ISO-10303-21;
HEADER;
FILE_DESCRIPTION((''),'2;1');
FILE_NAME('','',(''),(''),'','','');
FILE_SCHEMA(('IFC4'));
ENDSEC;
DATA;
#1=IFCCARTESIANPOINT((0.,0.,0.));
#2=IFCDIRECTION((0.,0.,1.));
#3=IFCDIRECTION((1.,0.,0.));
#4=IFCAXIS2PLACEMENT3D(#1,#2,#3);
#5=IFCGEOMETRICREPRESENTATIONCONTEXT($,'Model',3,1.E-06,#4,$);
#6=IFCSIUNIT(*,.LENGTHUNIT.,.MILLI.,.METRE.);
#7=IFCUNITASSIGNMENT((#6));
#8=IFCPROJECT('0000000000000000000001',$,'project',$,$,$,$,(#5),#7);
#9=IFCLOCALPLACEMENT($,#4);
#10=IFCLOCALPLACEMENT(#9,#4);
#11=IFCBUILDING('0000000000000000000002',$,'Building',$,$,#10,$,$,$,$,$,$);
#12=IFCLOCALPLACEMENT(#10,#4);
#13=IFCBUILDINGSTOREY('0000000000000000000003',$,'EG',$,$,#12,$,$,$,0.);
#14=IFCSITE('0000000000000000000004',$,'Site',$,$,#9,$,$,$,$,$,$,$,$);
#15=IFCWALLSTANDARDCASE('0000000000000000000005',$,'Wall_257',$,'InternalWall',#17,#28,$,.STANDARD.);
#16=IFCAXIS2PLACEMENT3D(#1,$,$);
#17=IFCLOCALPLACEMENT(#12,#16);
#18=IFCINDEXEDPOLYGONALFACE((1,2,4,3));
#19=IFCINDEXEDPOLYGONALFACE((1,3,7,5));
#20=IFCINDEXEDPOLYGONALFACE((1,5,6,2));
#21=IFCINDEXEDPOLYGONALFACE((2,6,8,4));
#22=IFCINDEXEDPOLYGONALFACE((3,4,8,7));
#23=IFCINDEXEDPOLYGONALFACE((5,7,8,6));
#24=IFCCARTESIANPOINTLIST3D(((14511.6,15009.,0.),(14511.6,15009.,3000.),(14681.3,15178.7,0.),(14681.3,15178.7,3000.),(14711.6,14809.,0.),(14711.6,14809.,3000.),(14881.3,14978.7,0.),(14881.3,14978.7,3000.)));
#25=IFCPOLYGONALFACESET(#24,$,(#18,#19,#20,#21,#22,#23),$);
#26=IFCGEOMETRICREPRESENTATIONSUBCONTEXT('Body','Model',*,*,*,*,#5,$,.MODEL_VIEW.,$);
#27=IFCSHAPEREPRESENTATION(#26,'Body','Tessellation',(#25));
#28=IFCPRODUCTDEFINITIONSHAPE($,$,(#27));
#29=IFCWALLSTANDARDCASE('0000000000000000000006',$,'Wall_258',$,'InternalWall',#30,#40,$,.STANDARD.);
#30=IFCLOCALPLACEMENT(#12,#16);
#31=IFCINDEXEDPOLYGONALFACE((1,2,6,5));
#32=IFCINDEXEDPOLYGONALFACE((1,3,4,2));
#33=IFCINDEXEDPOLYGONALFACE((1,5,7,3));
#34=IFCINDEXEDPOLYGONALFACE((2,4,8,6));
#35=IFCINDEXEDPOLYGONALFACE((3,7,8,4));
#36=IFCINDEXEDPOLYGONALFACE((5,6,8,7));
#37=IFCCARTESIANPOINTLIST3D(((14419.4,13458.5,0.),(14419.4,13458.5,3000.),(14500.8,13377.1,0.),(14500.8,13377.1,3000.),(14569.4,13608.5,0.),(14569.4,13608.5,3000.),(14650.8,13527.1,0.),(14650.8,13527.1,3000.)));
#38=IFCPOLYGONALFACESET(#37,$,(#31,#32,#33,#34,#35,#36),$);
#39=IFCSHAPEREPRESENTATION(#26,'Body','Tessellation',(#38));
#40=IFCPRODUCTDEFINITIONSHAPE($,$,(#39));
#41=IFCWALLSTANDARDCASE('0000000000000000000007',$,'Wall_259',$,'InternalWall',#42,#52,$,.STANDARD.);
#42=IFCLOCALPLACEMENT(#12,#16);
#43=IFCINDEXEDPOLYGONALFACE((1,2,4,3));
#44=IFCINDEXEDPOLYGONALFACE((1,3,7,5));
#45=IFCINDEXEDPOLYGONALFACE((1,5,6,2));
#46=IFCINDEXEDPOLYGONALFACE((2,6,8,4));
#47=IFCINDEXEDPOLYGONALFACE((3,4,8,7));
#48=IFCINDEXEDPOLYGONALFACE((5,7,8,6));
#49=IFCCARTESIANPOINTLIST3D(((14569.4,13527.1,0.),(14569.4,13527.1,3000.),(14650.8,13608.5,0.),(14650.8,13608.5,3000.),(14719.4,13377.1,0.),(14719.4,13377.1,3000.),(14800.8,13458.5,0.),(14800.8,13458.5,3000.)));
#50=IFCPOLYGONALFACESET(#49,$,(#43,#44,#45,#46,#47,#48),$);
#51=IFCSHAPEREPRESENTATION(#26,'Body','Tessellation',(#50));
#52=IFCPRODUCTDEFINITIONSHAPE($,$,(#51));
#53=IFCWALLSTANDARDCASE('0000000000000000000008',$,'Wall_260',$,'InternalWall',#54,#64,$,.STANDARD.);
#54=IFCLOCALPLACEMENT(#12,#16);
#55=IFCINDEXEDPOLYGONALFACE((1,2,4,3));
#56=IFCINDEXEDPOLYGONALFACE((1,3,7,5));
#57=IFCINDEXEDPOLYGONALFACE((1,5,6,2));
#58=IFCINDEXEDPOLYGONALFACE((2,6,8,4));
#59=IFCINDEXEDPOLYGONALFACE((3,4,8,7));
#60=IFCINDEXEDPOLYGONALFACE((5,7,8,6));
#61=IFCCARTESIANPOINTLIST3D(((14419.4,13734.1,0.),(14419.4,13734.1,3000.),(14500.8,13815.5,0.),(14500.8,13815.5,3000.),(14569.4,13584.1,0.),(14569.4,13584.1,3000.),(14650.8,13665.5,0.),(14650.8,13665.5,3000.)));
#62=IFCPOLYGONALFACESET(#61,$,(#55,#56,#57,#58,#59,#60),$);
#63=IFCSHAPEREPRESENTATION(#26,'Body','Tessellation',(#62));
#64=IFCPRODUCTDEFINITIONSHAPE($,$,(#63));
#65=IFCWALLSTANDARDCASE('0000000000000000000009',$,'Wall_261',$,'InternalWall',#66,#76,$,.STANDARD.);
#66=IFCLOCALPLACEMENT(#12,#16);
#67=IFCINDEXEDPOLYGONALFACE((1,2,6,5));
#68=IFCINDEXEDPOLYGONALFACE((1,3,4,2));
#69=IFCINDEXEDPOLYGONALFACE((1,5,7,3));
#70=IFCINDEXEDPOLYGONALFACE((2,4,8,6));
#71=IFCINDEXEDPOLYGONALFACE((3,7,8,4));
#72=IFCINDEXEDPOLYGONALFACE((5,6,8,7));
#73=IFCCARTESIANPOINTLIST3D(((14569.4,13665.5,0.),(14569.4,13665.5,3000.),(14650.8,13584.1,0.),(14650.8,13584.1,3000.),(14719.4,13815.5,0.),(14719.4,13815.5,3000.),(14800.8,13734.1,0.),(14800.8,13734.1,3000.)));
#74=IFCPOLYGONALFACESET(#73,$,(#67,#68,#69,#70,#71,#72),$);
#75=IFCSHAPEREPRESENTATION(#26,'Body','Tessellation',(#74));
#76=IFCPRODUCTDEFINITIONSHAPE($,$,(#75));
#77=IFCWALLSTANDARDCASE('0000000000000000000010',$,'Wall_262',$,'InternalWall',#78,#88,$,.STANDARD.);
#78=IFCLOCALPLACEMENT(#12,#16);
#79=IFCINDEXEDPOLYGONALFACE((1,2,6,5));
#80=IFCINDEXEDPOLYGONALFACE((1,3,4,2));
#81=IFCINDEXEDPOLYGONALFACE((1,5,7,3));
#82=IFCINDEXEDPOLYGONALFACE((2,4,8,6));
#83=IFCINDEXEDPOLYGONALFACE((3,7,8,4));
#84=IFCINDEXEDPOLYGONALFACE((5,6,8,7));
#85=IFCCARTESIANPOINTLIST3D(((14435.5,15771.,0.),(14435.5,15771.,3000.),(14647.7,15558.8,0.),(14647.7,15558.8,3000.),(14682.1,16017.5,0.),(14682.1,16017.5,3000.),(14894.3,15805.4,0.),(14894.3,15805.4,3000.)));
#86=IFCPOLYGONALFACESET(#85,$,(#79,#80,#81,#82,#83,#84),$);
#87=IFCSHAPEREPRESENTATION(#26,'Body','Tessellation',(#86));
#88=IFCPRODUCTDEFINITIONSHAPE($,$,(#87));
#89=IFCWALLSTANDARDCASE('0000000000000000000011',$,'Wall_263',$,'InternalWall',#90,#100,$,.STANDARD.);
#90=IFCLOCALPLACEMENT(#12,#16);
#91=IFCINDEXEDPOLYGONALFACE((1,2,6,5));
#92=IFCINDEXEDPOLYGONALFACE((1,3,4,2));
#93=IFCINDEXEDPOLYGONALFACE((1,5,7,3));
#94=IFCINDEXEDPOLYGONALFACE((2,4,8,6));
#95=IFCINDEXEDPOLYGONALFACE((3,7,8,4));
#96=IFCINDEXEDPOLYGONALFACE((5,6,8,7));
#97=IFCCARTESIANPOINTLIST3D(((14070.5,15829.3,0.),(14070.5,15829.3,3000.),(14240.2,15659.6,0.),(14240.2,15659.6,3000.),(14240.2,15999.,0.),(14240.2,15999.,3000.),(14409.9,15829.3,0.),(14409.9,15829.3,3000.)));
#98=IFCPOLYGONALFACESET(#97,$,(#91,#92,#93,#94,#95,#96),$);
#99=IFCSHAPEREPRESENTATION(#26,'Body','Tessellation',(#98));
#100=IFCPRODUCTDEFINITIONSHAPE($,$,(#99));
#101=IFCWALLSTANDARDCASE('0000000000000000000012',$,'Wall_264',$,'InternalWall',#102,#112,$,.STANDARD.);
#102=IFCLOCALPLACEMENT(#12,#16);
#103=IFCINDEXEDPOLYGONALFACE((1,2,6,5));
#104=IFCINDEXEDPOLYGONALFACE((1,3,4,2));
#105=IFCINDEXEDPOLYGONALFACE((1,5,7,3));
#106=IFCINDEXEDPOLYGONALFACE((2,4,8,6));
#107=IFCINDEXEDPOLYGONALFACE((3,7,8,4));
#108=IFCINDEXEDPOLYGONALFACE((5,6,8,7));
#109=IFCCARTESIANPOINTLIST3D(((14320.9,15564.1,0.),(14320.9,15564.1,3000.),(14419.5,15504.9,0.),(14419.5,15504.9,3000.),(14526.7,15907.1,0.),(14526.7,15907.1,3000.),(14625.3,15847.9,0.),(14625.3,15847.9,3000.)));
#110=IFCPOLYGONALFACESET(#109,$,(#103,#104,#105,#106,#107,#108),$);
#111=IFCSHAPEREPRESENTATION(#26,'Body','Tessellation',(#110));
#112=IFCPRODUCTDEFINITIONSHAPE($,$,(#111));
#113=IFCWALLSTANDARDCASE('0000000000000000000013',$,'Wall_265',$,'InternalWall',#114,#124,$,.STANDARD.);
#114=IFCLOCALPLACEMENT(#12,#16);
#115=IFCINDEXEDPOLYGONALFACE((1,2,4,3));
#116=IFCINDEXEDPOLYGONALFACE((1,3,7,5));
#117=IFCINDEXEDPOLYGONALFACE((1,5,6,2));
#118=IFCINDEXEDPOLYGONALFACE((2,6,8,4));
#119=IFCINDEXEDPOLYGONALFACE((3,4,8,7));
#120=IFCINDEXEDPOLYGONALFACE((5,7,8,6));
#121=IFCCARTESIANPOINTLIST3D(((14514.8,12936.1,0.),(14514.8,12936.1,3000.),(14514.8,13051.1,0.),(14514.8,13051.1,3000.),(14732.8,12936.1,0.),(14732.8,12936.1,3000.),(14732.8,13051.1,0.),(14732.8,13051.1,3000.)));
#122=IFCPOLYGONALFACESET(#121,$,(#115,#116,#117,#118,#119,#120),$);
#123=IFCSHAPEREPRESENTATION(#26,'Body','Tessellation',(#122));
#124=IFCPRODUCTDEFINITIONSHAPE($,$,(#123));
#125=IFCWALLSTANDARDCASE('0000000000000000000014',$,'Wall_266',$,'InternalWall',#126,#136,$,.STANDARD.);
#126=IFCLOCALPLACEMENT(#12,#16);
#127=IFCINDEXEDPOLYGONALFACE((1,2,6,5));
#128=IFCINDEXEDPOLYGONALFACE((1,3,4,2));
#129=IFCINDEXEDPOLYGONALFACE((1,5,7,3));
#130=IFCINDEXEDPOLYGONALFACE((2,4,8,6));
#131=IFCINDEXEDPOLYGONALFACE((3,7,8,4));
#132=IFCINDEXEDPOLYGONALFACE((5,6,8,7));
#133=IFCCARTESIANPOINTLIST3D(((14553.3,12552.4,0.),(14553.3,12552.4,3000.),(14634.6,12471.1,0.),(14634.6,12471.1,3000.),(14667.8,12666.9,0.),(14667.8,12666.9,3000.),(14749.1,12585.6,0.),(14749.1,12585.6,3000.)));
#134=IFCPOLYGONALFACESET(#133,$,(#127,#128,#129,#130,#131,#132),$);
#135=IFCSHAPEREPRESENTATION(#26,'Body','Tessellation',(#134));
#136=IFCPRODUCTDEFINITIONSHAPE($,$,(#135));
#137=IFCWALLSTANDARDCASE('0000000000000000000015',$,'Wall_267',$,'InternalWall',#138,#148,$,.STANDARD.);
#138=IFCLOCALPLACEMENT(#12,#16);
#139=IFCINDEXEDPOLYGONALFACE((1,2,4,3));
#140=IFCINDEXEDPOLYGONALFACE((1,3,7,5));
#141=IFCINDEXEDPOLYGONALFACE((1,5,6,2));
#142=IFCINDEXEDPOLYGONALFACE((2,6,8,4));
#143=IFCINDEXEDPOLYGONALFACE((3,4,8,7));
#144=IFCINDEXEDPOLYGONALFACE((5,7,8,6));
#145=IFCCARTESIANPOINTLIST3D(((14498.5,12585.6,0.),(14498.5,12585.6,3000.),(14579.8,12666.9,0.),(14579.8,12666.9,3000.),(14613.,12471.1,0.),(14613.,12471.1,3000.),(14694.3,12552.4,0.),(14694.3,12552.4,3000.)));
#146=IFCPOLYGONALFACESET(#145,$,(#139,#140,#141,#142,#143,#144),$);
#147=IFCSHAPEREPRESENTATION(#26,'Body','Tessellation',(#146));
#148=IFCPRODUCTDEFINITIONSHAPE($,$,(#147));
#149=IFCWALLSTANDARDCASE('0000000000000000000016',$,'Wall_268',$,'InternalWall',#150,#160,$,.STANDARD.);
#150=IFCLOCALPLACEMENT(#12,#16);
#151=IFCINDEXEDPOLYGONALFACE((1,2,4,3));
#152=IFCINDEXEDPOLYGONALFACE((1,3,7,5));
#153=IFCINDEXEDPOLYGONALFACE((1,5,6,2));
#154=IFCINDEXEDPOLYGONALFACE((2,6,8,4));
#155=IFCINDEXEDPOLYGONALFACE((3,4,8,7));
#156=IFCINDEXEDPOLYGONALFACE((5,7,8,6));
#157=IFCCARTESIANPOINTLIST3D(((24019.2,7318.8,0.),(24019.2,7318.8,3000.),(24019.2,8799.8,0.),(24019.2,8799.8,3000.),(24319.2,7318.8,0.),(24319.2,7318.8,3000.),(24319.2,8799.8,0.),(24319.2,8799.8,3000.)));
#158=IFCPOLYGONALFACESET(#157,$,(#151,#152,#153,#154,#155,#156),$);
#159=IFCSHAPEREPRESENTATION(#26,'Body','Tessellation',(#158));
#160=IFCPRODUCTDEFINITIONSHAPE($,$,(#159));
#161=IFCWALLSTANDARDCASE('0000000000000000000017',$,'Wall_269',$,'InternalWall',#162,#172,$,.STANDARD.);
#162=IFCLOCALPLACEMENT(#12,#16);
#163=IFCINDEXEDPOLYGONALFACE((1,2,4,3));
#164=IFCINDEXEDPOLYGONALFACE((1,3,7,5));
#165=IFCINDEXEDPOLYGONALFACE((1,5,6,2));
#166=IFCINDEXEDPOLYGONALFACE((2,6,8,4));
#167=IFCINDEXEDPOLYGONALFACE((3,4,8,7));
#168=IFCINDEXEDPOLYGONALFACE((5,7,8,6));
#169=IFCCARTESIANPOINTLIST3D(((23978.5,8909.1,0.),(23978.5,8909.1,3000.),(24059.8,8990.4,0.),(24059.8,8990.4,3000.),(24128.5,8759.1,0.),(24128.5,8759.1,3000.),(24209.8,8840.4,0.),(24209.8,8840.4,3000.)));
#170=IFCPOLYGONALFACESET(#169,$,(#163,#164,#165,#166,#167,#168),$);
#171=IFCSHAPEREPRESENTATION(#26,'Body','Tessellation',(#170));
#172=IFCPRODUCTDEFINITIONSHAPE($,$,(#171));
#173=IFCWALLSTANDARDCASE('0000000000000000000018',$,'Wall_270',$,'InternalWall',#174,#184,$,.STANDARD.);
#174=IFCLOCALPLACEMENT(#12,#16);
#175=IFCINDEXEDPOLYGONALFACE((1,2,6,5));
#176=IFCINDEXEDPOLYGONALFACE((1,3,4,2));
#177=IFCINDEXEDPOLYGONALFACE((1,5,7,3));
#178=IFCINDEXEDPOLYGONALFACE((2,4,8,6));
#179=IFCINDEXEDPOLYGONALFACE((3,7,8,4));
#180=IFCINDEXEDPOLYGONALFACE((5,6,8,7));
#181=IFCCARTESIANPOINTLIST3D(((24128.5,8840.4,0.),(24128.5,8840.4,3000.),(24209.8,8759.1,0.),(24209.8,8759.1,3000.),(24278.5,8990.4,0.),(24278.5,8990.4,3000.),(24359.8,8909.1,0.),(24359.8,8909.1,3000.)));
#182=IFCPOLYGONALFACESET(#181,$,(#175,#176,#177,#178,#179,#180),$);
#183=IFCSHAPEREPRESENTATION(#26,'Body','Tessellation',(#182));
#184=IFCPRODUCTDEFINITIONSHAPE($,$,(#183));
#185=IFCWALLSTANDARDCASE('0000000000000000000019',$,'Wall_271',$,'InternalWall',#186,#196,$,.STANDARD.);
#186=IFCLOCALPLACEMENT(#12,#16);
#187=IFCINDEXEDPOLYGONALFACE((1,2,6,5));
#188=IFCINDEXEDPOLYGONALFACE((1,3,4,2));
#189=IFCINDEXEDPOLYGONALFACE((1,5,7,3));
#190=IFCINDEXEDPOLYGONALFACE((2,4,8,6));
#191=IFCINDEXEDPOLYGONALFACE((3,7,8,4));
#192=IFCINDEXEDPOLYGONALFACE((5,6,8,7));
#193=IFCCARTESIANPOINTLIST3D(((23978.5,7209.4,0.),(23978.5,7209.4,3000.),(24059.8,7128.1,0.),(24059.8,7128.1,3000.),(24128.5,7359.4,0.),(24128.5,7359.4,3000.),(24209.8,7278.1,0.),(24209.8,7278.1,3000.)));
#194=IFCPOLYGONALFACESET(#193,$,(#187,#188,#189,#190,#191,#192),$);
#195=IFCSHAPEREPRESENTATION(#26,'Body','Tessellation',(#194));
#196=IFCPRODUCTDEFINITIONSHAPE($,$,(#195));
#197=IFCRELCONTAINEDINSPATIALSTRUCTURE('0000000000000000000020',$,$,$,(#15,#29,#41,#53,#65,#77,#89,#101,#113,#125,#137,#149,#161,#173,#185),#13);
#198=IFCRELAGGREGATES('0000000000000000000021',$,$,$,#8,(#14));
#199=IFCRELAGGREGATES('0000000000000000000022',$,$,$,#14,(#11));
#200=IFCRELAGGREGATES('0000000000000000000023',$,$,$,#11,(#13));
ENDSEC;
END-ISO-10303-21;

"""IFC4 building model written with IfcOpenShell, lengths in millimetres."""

from ifc_helpers import new_model, si_unit, frame, origin_with_axes, place, context, subcontext, project, spatial, rectangle, extrude, element, save


model = new_model("IFC4")

# Units and contexts
model_context = context("Model", 3, precision=1e-06, world=origin_with_axes())
body_context = subcontext(model_context, "Body", "Model", "MODEL_VIEW")
ifc_project = project(units=[si_unit("LENGTHUNIT", "METRE", prefix="MILLI")], contexts=[model_context])

# Site, building, storey
site_placement = place(None, origin_with_axes())
site = spatial("IfcSite", under=ifc_project, at=site_placement, Name="Site")
building_placement = place(site_placement, origin_with_axes())
building = spatial("IfcBuilding", under=site, at=building_placement, Name="Building")
storey_placement = place(building_placement, origin_with_axes())
storey = spatial("IfcBuildingStorey", under=building, at=storey_placement, Name="EG", Elevation=0.0)

# Walls
wall_1_placement = place(storey_placement, origin_with_axes())
element("IfcWallStandardCase", 1, at=wall_1_placement, inside=storey, Name="Wall_257", ObjectType="InternalWall", PredefinedType="STANDARD", context=body_context, shape_type="SweptSolid", body=[
    extrude(rectangle(XDim=282.8, YDim=240.0), frame((14696.4, 14993.9, 0.0), z_axis=(0.0, 0.0, 1.0), x_axis=(0.707107, -0.707107, 0.0)), (0.0, 0.0, 1.0), 3000.0),
])
wall_2_placement = place(storey_placement, origin_with_axes())
element("IfcWallStandardCase", 2, at=wall_2_placement, inside=storey, Name="Wall_258", ObjectType="InternalWall", PredefinedType="STANDARD", context=body_context, shape_type="SweptSolid", body=[
    extrude(rectangle(XDim=212.1, YDim=115.0), frame((14535.1, 13492.8, 0.0), z_axis=(0.0, 0.0, 1.0), x_axis=(-0.707107, -0.707107, 0.0)), (0.0, 0.0, 1.0), 3000.0),
])
wall_3_placement = place(storey_placement, origin_with_axes())
element("IfcWallStandardCase", 3, at=wall_3_placement, inside=storey, Name="Wall_259", ObjectType="InternalWall", PredefinedType="STANDARD", context=body_context, shape_type="SweptSolid", body=[
    extrude(rectangle(XDim=212.1, YDim=115.0), frame((14685.1, 13492.8, 0.0), z_axis=(0.0, 0.0, 1.0), x_axis=(0.707107, -0.707107, 0.0)), (0.0, 0.0, 1.0), 3000.0),
])
wall_4_placement = place(storey_placement, origin_with_axes())
element("IfcWallStandardCase", 4, at=wall_4_placement, inside=storey, Name="Wall_260", ObjectType="InternalWall", PredefinedType="STANDARD", context=body_context, shape_type="SweptSolid", body=[
    extrude(rectangle(XDim=212.1, YDim=115.0), frame((14535.1, 13699.8, 0.0), z_axis=(0.0, 0.0, 1.0), x_axis=(-0.707107, 0.707107, 0.0)), (0.0, 0.0, 1.0), 3000.0),
])
wall_5_placement = place(storey_placement, origin_with_axes())
element("IfcWallStandardCase", 5, at=wall_5_placement, inside=storey, Name="Wall_261", ObjectType="InternalWall", PredefinedType="STANDARD", context=body_context, shape_type="SweptSolid", body=[
    extrude(rectangle(XDim=212.1, YDim=115.0), frame((14685.1, 13699.8, 0.0), z_axis=(0.0, 0.0, 1.0), x_axis=(0.707107, 0.707107, 0.0)), (0.0, 0.0, 1.0), 3000.0),
])
wall_6_placement = place(storey_placement, origin_with_axes())
element("IfcWallStandardCase", 6, at=wall_6_placement, inside=storey, Name="Wall_262", ObjectType="InternalWall", PredefinedType="STANDARD", context=body_context, shape_type="SweptSolid", body=[
    extrude(rectangle(XDim=348.7, YDim=300.0), frame((14664.9, 15788.2, 0.0), z_axis=(0.0, 0.0, 1.0), x_axis=(-0.707107, -0.707107, 0.0)), (0.0, 0.0, 1.0), 3000.0),
])
wall_7_placement = place(storey_placement, origin_with_axes())
element("IfcWallStandardCase", 7, at=wall_7_placement, inside=storey, Name="Wall_263", ObjectType="InternalWall", PredefinedType="STANDARD", context=body_context, shape_type="SweptSolid", body=[
    extrude(rectangle(XDim=240.0, YDim=240.0), frame((14240.2, 15829.3, 0.0), z_axis=(0.0, 0.0, 1.0), x_axis=(-0.707107, -0.707107, 0.0)), (0.0, 0.0, 1.0), 3000.0),
])
wall_8_placement = place(storey_placement, origin_with_axes())
element("IfcWallStandardCase", 8, at=wall_8_placement, inside=storey, Name="Wall_264", ObjectType="InternalWall", PredefinedType="STANDARD", context=body_context, shape_type="SweptSolid", body=[
    extrude(rectangle(XDim=400.0, YDim=115.0), frame((14473.1, 15706.0, 0.0), z_axis=(0.0, 0.0, 1.0), x_axis=(0.514496, 0.857493, 0.0)), (0.0, 0.0, 1.0), 3000.0),
])
wall_9_placement = place(storey_placement, origin_with_axes())
element("IfcWallStandardCase", 9, at=wall_9_placement, inside=storey, Name="Wall_265", ObjectType="InternalWall", PredefinedType="STANDARD", context=body_context, shape_type="SweptSolid", body=[
    extrude(rectangle(XDim=218.0, YDim=115.0), frame((14623.8, 12993.6, 0.0), z_axis=(0.0, 0.0, 1.0), x_axis=(-1.0, 0.0, 0.0)), (0.0, 0.0, 1.0), 3000.0),
])
wall_10_placement = place(storey_placement, origin_with_axes())
element("IfcWallStandardCase", 10, at=wall_10_placement, inside=storey, Name="Wall_266", ObjectType="InternalWall", PredefinedType="STANDARD", context=body_context, shape_type="SweptSolid", body=[
    extrude(rectangle(XDim=161.9, YDim=115.0), frame((14651.2, 12569.0, 0.0), z_axis=(0.0, 0.0, 1.0), x_axis=(-0.707107, -0.707107, 0.0)), (0.0, 0.0, 1.0), 3000.0),
])
wall_11_placement = place(storey_placement, origin_with_axes())
element("IfcWallStandardCase", 11, at=wall_11_placement, inside=storey, Name="Wall_267", ObjectType="InternalWall", PredefinedType="STANDARD", context=body_context, shape_type="SweptSolid", body=[
    extrude(rectangle(XDim=161.9, YDim=115.0), frame((14596.4, 12569.0, 0.0), z_axis=(0.0, 0.0, 1.0), x_axis=(0.707107, -0.707107, 0.0)), (0.0, 0.0, 1.0), 3000.0),
])
wall_12_placement = place(storey_placement, origin_with_axes())
element("IfcWallStandardCase", 12, at=wall_12_placement, inside=storey, Name="Wall_268", ObjectType="InternalWall", PredefinedType="STANDARD", context=body_context, shape_type="SweptSolid", body=[
    extrude(rectangle(XDim=1481.0, YDim=300.0), frame((24169.2, 8059.3, 0.0), z_axis=(0.0, 0.0, 1.0), x_axis=(0.0, -1.0, 0.0)), (0.0, 0.0, 1.0), 3000.0),
])
wall_13_placement = place(storey_placement, origin_with_axes())
element("IfcWallStandardCase", 13, at=wall_13_placement, inside=storey, Name="Wall_269", ObjectType="InternalWall", PredefinedType="STANDARD", context=body_context, shape_type="SweptSolid", body=[
    extrude(rectangle(XDim=212.1, YDim=115.0), frame((24094.2, 8874.8, 0.0), z_axis=(0.0, 0.0, 1.0), x_axis=(-0.707107, 0.707107, 0.0)), (0.0, 0.0, 1.0), 3000.0),
])
wall_14_placement = place(storey_placement, origin_with_axes())
element("IfcWallStandardCase", 14, at=wall_14_placement, inside=storey, Name="Wall_270", ObjectType="InternalWall", PredefinedType="STANDARD", context=body_context, shape_type="SweptSolid", body=[
    extrude(rectangle(XDim=212.1, YDim=115.0), frame((24244.2, 8874.8, 0.0), z_axis=(0.0, 0.0, 1.0), x_axis=(0.707107, 0.707107, 0.0)), (0.0, 0.0, 1.0), 3000.0),
])
wall_15_placement = place(storey_placement, origin_with_axes())
element("IfcWallStandardCase", 15, at=wall_15_placement, inside=storey, Name="Wall_271", ObjectType="InternalWall", PredefinedType="STANDARD", context=body_context, shape_type="SweptSolid", body=[
    extrude(rectangle(XDim=212.1, YDim=115.0), frame((24094.2, 7243.8, 0.0), z_axis=(0.0, 0.0, 1.0), x_axis=(-0.707107, -0.707107, 0.0)), (0.0, 0.0, 1.0), 3000.0),
])

save(model, "model.ifc")
